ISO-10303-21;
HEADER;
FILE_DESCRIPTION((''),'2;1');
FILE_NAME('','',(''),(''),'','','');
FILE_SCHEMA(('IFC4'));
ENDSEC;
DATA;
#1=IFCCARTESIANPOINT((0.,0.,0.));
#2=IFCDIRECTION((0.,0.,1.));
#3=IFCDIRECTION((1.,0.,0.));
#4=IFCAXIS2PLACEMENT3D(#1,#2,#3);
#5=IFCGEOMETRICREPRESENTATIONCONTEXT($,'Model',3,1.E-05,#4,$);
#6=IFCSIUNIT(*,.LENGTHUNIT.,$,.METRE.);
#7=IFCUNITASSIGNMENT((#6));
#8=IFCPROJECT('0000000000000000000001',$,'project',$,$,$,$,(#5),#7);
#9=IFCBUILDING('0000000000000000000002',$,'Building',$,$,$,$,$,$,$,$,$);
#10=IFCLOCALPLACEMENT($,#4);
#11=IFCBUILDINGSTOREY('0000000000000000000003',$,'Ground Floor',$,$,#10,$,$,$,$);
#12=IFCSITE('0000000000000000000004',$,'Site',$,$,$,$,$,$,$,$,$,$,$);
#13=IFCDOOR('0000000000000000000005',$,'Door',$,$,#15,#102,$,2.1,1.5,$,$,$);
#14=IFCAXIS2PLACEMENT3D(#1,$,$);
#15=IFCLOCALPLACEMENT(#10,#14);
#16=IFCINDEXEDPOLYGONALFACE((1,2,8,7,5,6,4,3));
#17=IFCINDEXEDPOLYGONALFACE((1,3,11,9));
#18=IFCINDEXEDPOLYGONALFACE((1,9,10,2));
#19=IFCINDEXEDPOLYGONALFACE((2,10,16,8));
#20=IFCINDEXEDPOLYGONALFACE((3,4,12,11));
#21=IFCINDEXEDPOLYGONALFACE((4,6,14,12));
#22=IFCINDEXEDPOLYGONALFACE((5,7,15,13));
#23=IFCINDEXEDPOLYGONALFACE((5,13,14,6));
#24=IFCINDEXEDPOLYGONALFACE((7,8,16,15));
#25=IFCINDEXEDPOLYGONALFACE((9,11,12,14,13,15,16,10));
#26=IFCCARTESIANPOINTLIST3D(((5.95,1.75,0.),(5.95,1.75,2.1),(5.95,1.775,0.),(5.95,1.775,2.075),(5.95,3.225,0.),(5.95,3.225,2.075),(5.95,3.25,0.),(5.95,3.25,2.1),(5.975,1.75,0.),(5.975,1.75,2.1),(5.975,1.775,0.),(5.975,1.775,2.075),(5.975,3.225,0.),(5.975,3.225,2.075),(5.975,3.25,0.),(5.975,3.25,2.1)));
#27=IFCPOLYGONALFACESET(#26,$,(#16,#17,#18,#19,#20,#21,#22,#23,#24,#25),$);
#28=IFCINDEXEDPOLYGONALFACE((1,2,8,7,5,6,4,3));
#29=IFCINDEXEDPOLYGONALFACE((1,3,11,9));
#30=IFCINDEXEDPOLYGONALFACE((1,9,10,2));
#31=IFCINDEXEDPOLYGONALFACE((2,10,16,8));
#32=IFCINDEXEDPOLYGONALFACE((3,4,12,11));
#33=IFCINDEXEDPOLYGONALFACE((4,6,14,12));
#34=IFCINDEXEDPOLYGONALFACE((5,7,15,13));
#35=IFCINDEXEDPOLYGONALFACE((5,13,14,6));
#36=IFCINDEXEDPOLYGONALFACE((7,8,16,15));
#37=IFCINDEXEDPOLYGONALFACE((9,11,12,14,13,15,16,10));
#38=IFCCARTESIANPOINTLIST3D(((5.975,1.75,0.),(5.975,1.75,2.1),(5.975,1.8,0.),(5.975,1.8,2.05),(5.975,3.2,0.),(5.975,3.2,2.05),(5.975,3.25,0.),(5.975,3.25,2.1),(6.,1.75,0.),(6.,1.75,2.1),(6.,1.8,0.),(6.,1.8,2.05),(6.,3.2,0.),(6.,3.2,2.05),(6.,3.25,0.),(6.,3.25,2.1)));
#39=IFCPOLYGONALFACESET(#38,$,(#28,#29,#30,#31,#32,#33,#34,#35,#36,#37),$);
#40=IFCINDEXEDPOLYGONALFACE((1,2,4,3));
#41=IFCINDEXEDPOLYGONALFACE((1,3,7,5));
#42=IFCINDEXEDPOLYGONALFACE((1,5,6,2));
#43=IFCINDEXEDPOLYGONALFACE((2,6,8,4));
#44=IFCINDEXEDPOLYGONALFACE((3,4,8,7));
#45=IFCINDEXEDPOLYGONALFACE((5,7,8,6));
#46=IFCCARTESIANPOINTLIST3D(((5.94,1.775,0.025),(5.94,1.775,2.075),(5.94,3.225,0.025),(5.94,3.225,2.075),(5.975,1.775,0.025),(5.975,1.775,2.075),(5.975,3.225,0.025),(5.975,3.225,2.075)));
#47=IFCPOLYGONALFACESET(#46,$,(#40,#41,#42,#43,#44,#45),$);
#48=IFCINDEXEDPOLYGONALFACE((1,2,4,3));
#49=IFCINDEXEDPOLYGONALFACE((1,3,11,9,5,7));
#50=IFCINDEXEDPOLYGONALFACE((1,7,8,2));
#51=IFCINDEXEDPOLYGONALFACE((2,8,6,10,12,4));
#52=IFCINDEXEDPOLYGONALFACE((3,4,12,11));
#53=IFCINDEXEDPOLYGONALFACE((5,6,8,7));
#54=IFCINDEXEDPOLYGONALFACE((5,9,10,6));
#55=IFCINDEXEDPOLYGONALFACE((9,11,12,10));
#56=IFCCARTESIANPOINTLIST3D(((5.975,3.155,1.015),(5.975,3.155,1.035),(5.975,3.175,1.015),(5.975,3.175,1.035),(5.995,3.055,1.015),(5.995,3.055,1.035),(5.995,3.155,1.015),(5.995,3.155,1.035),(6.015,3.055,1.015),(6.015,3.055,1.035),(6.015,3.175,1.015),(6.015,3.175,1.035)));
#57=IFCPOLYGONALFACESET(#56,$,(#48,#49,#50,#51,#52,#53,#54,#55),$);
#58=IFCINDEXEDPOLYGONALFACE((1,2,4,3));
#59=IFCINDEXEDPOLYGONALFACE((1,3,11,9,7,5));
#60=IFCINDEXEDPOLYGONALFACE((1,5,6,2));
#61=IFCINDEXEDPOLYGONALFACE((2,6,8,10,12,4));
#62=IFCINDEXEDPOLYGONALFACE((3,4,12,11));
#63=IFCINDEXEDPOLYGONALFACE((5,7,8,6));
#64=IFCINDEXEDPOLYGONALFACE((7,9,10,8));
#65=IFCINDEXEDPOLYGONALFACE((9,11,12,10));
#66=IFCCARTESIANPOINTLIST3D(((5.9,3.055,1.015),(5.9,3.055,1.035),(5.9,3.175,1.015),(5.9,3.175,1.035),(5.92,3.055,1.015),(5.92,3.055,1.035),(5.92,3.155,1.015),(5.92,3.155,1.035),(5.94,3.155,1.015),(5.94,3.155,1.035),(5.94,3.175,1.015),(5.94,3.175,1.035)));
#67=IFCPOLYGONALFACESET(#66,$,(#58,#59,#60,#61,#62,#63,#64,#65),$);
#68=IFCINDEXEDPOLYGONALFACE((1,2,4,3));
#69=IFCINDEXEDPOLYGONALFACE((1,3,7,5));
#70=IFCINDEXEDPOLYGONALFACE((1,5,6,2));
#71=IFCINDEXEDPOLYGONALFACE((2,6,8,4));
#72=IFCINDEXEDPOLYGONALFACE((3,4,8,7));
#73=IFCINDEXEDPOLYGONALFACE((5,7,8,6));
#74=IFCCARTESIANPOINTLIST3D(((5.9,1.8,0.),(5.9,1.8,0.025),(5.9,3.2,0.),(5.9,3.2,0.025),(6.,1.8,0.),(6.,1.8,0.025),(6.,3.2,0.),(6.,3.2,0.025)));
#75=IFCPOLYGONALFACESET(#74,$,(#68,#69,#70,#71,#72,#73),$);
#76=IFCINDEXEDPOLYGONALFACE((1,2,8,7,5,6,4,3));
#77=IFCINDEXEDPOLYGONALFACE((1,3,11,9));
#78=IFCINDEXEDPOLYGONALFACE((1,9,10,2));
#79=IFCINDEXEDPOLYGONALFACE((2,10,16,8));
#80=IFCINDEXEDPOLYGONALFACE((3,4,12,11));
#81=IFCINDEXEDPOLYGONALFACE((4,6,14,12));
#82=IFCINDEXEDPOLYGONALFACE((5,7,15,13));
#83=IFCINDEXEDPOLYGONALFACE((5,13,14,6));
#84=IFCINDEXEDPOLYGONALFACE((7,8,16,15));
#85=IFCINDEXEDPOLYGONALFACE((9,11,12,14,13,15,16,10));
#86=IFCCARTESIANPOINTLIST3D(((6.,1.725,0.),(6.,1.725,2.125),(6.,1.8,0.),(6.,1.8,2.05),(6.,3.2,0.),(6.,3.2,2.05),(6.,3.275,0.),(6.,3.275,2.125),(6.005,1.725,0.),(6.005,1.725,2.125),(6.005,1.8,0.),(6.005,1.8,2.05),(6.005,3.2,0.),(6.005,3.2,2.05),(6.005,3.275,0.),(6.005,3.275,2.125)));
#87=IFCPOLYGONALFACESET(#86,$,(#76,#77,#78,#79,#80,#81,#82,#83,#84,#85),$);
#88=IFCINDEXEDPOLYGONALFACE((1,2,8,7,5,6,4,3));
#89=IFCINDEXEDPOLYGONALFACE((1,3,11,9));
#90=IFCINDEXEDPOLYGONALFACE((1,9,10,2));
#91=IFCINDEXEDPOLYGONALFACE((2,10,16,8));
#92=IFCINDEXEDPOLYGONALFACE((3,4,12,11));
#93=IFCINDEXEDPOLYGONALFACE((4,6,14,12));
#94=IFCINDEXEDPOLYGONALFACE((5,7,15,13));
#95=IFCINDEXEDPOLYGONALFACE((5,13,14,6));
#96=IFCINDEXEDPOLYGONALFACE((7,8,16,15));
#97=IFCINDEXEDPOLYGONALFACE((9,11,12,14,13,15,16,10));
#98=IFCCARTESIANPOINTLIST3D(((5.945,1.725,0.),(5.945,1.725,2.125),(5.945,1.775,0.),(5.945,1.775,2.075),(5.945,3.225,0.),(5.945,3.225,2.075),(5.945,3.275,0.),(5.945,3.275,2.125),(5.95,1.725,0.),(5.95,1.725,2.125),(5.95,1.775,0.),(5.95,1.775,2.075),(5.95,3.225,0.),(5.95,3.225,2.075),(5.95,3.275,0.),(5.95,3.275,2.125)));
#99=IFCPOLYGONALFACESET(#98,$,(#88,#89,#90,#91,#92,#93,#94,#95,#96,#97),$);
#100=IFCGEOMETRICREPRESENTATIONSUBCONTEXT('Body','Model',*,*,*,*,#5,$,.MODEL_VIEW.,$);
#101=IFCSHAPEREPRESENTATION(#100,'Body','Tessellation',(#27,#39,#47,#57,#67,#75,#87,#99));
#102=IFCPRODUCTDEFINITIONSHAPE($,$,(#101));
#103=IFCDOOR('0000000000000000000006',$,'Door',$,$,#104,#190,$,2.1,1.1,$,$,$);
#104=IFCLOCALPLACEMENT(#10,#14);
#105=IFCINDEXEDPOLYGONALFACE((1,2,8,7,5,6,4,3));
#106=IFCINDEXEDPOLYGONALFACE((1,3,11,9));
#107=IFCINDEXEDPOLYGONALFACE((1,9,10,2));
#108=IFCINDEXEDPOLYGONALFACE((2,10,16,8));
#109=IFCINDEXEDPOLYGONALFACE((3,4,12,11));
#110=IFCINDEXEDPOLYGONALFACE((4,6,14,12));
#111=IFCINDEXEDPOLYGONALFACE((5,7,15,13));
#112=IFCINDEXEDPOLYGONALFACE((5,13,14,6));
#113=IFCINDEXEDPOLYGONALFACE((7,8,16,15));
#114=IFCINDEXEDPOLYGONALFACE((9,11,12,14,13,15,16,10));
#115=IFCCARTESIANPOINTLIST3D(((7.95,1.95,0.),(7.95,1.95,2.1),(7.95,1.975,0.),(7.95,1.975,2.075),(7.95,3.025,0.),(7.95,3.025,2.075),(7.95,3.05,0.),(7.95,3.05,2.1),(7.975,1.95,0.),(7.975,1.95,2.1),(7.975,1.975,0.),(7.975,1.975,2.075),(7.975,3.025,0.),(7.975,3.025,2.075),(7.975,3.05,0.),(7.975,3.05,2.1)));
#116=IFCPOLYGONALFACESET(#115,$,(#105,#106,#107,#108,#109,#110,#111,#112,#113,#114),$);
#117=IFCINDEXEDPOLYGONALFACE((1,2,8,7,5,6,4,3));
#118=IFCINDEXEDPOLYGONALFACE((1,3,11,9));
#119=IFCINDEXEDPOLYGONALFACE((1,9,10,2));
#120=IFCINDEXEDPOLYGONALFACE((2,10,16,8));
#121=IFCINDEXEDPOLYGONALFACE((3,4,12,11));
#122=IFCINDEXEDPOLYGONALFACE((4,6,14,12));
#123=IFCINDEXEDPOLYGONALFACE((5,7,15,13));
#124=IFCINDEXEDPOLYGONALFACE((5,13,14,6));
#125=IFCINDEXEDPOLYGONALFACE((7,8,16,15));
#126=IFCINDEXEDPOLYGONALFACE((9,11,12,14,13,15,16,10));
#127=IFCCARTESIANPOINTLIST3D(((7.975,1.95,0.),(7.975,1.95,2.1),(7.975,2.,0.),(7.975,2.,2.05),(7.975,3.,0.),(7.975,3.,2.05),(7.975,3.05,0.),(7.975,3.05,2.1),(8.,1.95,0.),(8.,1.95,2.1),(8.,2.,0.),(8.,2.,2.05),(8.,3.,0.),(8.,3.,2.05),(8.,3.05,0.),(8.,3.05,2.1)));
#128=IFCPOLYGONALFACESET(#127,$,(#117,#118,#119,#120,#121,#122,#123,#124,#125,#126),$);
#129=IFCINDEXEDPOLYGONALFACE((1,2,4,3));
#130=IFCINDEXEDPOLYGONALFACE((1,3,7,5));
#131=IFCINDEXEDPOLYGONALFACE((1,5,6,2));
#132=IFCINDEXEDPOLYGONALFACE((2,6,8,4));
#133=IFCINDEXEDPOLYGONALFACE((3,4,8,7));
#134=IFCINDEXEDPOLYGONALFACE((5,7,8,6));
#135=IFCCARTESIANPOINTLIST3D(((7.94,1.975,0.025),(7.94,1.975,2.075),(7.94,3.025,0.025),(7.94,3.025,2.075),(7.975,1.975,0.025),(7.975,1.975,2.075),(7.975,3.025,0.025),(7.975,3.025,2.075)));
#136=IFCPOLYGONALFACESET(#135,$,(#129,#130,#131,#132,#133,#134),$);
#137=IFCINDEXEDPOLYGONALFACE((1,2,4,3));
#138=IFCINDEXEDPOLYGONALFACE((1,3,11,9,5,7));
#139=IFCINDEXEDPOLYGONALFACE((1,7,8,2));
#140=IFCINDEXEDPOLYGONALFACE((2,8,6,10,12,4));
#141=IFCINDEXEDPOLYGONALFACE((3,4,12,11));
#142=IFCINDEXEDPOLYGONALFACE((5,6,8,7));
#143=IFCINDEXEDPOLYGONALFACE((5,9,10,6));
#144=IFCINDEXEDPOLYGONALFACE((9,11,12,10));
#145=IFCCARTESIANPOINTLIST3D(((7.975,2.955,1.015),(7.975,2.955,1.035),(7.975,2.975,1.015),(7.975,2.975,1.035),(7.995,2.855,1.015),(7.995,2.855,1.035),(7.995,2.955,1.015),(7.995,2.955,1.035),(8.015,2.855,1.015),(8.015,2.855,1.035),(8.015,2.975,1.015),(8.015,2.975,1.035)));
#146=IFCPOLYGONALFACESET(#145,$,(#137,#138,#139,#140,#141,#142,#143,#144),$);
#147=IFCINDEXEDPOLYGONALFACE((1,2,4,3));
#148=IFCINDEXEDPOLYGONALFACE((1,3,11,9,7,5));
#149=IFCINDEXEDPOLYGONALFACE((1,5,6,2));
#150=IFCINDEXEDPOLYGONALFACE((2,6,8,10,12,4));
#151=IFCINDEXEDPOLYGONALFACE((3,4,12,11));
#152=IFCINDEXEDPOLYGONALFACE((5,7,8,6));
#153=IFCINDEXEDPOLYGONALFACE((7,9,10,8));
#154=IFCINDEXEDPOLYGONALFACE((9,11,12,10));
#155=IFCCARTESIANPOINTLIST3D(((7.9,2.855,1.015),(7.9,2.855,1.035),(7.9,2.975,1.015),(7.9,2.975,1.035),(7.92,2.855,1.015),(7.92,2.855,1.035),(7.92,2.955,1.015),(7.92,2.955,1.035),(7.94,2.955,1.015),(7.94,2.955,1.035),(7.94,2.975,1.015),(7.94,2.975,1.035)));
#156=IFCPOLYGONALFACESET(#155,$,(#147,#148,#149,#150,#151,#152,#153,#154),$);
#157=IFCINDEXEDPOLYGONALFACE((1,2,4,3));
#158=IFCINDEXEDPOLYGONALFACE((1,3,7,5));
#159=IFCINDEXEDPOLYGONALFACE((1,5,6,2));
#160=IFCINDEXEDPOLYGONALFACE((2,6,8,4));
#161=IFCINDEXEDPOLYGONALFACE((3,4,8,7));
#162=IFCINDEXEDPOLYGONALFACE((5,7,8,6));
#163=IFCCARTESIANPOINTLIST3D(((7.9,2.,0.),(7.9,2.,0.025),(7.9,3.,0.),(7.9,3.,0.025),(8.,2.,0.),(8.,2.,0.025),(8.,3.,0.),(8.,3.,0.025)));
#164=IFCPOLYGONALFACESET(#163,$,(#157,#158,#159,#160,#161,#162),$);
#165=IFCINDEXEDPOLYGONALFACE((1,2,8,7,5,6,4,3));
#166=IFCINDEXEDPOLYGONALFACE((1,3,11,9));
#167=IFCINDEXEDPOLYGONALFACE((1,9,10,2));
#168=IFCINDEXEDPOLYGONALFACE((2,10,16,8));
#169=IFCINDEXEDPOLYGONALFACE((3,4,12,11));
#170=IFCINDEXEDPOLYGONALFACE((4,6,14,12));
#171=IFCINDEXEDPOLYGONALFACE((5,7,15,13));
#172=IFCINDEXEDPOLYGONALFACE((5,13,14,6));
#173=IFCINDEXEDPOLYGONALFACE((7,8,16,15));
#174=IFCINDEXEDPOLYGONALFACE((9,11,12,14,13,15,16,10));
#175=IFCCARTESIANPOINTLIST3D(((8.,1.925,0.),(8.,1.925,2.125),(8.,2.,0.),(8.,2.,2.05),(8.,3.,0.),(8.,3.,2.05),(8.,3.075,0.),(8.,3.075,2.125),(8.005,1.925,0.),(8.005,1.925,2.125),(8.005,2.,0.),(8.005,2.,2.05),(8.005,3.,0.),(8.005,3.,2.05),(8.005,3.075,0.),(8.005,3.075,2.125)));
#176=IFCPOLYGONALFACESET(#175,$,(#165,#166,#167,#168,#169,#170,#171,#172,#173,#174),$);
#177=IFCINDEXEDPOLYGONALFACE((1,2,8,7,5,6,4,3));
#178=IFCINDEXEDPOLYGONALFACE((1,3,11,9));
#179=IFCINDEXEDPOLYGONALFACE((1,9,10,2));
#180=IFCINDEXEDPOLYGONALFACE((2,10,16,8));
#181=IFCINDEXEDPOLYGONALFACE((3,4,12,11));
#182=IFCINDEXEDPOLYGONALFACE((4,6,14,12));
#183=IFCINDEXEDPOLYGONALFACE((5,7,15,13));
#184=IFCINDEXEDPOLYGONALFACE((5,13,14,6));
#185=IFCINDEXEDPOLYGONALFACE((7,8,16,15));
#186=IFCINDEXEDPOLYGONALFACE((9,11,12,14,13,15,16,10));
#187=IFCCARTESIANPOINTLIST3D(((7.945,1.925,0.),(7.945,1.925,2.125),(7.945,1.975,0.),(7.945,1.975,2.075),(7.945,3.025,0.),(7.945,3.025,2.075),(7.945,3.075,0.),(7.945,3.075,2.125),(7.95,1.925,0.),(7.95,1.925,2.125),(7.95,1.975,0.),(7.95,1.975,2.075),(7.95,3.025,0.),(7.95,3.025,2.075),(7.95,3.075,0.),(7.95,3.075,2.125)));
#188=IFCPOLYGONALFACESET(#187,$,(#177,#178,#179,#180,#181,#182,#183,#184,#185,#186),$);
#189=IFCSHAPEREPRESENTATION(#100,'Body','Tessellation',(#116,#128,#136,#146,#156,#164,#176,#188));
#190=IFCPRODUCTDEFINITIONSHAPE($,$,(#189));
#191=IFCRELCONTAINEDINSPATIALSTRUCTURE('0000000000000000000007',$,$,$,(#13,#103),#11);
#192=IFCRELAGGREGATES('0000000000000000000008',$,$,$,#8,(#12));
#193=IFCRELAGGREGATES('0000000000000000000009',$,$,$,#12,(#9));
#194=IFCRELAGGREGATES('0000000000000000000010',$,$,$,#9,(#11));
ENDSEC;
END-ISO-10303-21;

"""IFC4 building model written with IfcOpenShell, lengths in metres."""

from ifc_helpers import new_model, si_unit, frame, origin_with_axes, place, context, subcontext, project, spatial, line, indexed_curve, outline, extrude, element, save


model = new_model("IFC4")

# Units and contexts
model_context = context("Model", 3, precision=1e-05, world=origin_with_axes())
body_context = subcontext(model_context, "Body", "Model", "MODEL_VIEW")
ifc_project = project(units=[si_unit("LENGTHUNIT", "METRE")], contexts=[model_context])

# Site, building, storey
site = spatial("IfcSite", under=ifc_project, Name="Site")
building = spatial("IfcBuilding", under=site, Name="Building")
storey_placement = place(None, origin_with_axes())
storey = spatial("IfcBuildingStorey", under=building, at=storey_placement, Name="Ground Floor")

# Doors
door_1_placement = place(storey_placement, frame((6.0, 1.75, 0.0), z_axis=(0.0, 0.0, 1.0), x_axis=(0.0, 1.0, 0.0)))
element("IfcDoor", 1, at=door_1_placement, inside=storey, Name="Door", OverallHeight=2.1, OverallWidth=1.5, context=body_context, shape_type="SweptSolid", body=[
    extrude(outline(indexed_curve([(0.0, 0.0), (0.0, 2.1), (1.5, 2.1), (1.5, 0.0), (1.475, 0.0), (1.475, 2.075), (0.025, 2.075), (0.025, 0.0)], segments=[line(1, 2, 3, 4, 5, 6, 7, 8, 1)])), frame((0.0, 0.025, 0.0), z_axis=(0.0, -1.0, 0.0), x_axis=(1.0, 0.0, 0.0)), (0.0, 0.0, -1.0), 0.025),
    extrude(outline(indexed_curve([(0.0, 0.0), (0.0, 2.1), (1.5, 2.1), (1.5, 0.0), (1.45, 0.0), (1.45, 2.05), (0.05, 2.05), (0.05, 0.0)], segments=[line(1, 2, 3, 4, 5, 6, 7, 8, 1)])), frame((0.0, 0.0, 0.0), z_axis=(0.0, -1.0, 0.0), x_axis=(1.0, 0.0, 0.0)), (0.0, 0.0, -1.0), 0.025),
    extrude(outline(indexed_curve([(0.0, 0.0), (1.45, 0.0), (1.45, 0.035), (0.0, 0.035)], segments=[line(1, 2, 3, 4, 1)])), frame((0.025, 0.025, 0.025), z_axis=(0.0, 0.0, 1.0), x_axis=(1.0, 0.0, 0.0)), (0.0, 0.0, 1.0), 2.05),
    extrude(outline(indexed_curve([(0.0, 0.0), (0.0, -0.04), (-0.12, -0.04), (-0.12, -0.02), (-0.02, -0.02), (-0.02, 0.0)], segments=[line(1, 2, 3, 4, 5, 6, 1)])), frame((1.425, 0.025, 1.015), z_axis=(0.0, 0.0, 1.0), x_axis=(1.0, 0.0, 0.0)), (0.0, 0.0, 1.0), 0.02),
    extrude(outline(indexed_curve([(0.0, 0.0), (0.0, 0.04), (-0.12, 0.04), (-0.12, 0.02), (-0.02, 0.02), (-0.02, 0.0)], segments=[line(1, 2, 3, 4, 5, 6, 1)])), frame((1.425, 0.06, 1.015), z_axis=(0.0, 0.0, 1.0), x_axis=(1.0, 0.0, 0.0)), (0.0, 0.0, 1.0), 0.02),
    extrude(outline(indexed_curve([(0.0, 0.0), (1.4, 0.0), (1.4, 0.1), (0.0, 0.1)], segments=[line(1, 2, 3, 4, 1)])), frame((0.05, 0.0, 0.0), z_axis=(0.0, 0.0, 1.0), x_axis=(1.0, 0.0, 0.0)), (0.0, 0.0, 1.0), 0.025),
    extrude(outline(indexed_curve([(0.0, 0.0), (0.0, 2.125), (1.55, 2.125), (1.55, 0.0), (1.475, 0.0), (1.475, 2.05), (0.075, 2.05), (0.075, 0.0)], segments=[line(1, 2, 3, 4, 5, 6, 7, 8, 1)])), frame((-0.025, -0.005, 0.0), z_axis=(0.0, -1.0, 0.0), x_axis=(1.0, 0.0, 0.0)), (0.0, 0.0, -1.0), 0.005),
    extrude(outline(indexed_curve([(0.0, 0.0), (0.0, 2.125), (1.55, 2.125), (1.55, 0.0), (1.5, 0.0), (1.5, 2.075), (0.05, 2.075), (0.05, 0.0)], segments=[line(1, 2, 3, 4, 5, 6, 7, 8, 1)])), frame((-0.025, 0.05, 0.0), z_axis=(0.0, -1.0, 0.0), x_axis=(1.0, 0.0, 0.0)), (0.0, 0.0, -1.0), 0.005),
])
door_2_placement = place(storey_placement, frame((8.0, 1.95, 0.0), z_axis=(0.0, 0.0, 1.0), x_axis=(0.0, 1.0, 0.0)))
element("IfcDoor", 2, at=door_2_placement, inside=storey, Name="Door", OverallHeight=2.1, OverallWidth=1.1, context=body_context, shape_type="SweptSolid", body=[
    extrude(outline(indexed_curve([(0.0, 0.0), (0.0, 2.1), (1.1, 2.1), (1.1, 0.0), (1.075, 0.0), (1.075, 2.075), (0.025, 2.075), (0.025, 0.0)], segments=[line(1, 2, 3, 4, 5, 6, 7, 8, 1)])), frame((0.0, 0.025, 0.0), z_axis=(0.0, -1.0, 0.0), x_axis=(1.0, 0.0, 0.0)), (0.0, 0.0, -1.0), 0.025),
    extrude(outline(indexed_curve([(0.0, 0.0), (0.0, 2.1), (1.1, 2.1), (1.1, 0.0), (1.05, 0.0), (1.05, 2.05), (0.05, 2.05), (0.05, 0.0)], segments=[line(1, 2, 3, 4, 5, 6, 7, 8, 1)])), frame((0.0, 0.0, 0.0), z_axis=(0.0, -1.0, 0.0), x_axis=(1.0, 0.0, 0.0)), (0.0, 0.0, -1.0), 0.025),
    extrude(outline(indexed_curve([(0.0, 0.0), (1.05, 0.0), (1.05, 0.035), (0.0, 0.035)], segments=[line(1, 2, 3, 4, 1)])), frame((0.025, 0.025, 0.025), z_axis=(0.0, 0.0, 1.0), x_axis=(1.0, 0.0, 0.0)), (0.0, 0.0, 1.0), 2.05),
    extrude(outline(indexed_curve([(0.0, 0.0), (0.0, -0.04), (-0.12, -0.04), (-0.12, -0.02), (-0.02, -0.02), (-0.02, 0.0)], segments=[line(1, 2, 3, 4, 5, 6, 1)])), frame((1.025, 0.025, 1.015), z_axis=(0.0, 0.0, 1.0), x_axis=(1.0, 0.0, 0.0)), (0.0, 0.0, 1.0), 0.02),
    extrude(outline(indexed_curve([(0.0, 0.0), (0.0, 0.04), (-0.12, 0.04), (-0.12, 0.02), (-0.02, 0.02), (-0.02, 0.0)], segments=[line(1, 2, 3, 4, 5, 6, 1)])), frame((1.025, 0.06, 1.015), z_axis=(0.0, 0.0, 1.0), x_axis=(1.0, 0.0, 0.0)), (0.0, 0.0, 1.0), 0.02),
    extrude(outline(indexed_curve([(0.0, 0.0), (1.0, 0.0), (1.0, 0.1), (0.0, 0.1)], segments=[line(1, 2, 3, 4, 1)])), frame((0.05, 0.0, 0.0), z_axis=(0.0, 0.0, 1.0), x_axis=(1.0, 0.0, 0.0)), (0.0, 0.0, 1.0), 0.025),
    extrude(outline(indexed_curve([(0.0, 0.0), (0.0, 2.125), (1.15, 2.125), (1.15, 0.0), (1.075, 0.0), (1.075, 2.05), (0.075, 2.05), (0.075, 0.0)], segments=[line(1, 2, 3, 4, 5, 6, 7, 8, 1)])), frame((-0.025, -0.005, 0.0), z_axis=(0.0, -1.0, 0.0), x_axis=(1.0, 0.0, 0.0)), (0.0, 0.0, -1.0), 0.005),
    extrude(outline(indexed_curve([(0.0, 0.0), (0.0, 2.125), (1.15, 2.125), (1.15, 0.0), (1.1, 0.0), (1.1, 2.075), (0.05, 2.075), (0.05, 0.0)], segments=[line(1, 2, 3, 4, 5, 6, 7, 8, 1)])), frame((-0.025, 0.05, 0.0), z_axis=(0.0, -1.0, 0.0), x_axis=(1.0, 0.0, 0.0)), (0.0, 0.0, -1.0), 0.005),
])

save(model, "model.ifc")
